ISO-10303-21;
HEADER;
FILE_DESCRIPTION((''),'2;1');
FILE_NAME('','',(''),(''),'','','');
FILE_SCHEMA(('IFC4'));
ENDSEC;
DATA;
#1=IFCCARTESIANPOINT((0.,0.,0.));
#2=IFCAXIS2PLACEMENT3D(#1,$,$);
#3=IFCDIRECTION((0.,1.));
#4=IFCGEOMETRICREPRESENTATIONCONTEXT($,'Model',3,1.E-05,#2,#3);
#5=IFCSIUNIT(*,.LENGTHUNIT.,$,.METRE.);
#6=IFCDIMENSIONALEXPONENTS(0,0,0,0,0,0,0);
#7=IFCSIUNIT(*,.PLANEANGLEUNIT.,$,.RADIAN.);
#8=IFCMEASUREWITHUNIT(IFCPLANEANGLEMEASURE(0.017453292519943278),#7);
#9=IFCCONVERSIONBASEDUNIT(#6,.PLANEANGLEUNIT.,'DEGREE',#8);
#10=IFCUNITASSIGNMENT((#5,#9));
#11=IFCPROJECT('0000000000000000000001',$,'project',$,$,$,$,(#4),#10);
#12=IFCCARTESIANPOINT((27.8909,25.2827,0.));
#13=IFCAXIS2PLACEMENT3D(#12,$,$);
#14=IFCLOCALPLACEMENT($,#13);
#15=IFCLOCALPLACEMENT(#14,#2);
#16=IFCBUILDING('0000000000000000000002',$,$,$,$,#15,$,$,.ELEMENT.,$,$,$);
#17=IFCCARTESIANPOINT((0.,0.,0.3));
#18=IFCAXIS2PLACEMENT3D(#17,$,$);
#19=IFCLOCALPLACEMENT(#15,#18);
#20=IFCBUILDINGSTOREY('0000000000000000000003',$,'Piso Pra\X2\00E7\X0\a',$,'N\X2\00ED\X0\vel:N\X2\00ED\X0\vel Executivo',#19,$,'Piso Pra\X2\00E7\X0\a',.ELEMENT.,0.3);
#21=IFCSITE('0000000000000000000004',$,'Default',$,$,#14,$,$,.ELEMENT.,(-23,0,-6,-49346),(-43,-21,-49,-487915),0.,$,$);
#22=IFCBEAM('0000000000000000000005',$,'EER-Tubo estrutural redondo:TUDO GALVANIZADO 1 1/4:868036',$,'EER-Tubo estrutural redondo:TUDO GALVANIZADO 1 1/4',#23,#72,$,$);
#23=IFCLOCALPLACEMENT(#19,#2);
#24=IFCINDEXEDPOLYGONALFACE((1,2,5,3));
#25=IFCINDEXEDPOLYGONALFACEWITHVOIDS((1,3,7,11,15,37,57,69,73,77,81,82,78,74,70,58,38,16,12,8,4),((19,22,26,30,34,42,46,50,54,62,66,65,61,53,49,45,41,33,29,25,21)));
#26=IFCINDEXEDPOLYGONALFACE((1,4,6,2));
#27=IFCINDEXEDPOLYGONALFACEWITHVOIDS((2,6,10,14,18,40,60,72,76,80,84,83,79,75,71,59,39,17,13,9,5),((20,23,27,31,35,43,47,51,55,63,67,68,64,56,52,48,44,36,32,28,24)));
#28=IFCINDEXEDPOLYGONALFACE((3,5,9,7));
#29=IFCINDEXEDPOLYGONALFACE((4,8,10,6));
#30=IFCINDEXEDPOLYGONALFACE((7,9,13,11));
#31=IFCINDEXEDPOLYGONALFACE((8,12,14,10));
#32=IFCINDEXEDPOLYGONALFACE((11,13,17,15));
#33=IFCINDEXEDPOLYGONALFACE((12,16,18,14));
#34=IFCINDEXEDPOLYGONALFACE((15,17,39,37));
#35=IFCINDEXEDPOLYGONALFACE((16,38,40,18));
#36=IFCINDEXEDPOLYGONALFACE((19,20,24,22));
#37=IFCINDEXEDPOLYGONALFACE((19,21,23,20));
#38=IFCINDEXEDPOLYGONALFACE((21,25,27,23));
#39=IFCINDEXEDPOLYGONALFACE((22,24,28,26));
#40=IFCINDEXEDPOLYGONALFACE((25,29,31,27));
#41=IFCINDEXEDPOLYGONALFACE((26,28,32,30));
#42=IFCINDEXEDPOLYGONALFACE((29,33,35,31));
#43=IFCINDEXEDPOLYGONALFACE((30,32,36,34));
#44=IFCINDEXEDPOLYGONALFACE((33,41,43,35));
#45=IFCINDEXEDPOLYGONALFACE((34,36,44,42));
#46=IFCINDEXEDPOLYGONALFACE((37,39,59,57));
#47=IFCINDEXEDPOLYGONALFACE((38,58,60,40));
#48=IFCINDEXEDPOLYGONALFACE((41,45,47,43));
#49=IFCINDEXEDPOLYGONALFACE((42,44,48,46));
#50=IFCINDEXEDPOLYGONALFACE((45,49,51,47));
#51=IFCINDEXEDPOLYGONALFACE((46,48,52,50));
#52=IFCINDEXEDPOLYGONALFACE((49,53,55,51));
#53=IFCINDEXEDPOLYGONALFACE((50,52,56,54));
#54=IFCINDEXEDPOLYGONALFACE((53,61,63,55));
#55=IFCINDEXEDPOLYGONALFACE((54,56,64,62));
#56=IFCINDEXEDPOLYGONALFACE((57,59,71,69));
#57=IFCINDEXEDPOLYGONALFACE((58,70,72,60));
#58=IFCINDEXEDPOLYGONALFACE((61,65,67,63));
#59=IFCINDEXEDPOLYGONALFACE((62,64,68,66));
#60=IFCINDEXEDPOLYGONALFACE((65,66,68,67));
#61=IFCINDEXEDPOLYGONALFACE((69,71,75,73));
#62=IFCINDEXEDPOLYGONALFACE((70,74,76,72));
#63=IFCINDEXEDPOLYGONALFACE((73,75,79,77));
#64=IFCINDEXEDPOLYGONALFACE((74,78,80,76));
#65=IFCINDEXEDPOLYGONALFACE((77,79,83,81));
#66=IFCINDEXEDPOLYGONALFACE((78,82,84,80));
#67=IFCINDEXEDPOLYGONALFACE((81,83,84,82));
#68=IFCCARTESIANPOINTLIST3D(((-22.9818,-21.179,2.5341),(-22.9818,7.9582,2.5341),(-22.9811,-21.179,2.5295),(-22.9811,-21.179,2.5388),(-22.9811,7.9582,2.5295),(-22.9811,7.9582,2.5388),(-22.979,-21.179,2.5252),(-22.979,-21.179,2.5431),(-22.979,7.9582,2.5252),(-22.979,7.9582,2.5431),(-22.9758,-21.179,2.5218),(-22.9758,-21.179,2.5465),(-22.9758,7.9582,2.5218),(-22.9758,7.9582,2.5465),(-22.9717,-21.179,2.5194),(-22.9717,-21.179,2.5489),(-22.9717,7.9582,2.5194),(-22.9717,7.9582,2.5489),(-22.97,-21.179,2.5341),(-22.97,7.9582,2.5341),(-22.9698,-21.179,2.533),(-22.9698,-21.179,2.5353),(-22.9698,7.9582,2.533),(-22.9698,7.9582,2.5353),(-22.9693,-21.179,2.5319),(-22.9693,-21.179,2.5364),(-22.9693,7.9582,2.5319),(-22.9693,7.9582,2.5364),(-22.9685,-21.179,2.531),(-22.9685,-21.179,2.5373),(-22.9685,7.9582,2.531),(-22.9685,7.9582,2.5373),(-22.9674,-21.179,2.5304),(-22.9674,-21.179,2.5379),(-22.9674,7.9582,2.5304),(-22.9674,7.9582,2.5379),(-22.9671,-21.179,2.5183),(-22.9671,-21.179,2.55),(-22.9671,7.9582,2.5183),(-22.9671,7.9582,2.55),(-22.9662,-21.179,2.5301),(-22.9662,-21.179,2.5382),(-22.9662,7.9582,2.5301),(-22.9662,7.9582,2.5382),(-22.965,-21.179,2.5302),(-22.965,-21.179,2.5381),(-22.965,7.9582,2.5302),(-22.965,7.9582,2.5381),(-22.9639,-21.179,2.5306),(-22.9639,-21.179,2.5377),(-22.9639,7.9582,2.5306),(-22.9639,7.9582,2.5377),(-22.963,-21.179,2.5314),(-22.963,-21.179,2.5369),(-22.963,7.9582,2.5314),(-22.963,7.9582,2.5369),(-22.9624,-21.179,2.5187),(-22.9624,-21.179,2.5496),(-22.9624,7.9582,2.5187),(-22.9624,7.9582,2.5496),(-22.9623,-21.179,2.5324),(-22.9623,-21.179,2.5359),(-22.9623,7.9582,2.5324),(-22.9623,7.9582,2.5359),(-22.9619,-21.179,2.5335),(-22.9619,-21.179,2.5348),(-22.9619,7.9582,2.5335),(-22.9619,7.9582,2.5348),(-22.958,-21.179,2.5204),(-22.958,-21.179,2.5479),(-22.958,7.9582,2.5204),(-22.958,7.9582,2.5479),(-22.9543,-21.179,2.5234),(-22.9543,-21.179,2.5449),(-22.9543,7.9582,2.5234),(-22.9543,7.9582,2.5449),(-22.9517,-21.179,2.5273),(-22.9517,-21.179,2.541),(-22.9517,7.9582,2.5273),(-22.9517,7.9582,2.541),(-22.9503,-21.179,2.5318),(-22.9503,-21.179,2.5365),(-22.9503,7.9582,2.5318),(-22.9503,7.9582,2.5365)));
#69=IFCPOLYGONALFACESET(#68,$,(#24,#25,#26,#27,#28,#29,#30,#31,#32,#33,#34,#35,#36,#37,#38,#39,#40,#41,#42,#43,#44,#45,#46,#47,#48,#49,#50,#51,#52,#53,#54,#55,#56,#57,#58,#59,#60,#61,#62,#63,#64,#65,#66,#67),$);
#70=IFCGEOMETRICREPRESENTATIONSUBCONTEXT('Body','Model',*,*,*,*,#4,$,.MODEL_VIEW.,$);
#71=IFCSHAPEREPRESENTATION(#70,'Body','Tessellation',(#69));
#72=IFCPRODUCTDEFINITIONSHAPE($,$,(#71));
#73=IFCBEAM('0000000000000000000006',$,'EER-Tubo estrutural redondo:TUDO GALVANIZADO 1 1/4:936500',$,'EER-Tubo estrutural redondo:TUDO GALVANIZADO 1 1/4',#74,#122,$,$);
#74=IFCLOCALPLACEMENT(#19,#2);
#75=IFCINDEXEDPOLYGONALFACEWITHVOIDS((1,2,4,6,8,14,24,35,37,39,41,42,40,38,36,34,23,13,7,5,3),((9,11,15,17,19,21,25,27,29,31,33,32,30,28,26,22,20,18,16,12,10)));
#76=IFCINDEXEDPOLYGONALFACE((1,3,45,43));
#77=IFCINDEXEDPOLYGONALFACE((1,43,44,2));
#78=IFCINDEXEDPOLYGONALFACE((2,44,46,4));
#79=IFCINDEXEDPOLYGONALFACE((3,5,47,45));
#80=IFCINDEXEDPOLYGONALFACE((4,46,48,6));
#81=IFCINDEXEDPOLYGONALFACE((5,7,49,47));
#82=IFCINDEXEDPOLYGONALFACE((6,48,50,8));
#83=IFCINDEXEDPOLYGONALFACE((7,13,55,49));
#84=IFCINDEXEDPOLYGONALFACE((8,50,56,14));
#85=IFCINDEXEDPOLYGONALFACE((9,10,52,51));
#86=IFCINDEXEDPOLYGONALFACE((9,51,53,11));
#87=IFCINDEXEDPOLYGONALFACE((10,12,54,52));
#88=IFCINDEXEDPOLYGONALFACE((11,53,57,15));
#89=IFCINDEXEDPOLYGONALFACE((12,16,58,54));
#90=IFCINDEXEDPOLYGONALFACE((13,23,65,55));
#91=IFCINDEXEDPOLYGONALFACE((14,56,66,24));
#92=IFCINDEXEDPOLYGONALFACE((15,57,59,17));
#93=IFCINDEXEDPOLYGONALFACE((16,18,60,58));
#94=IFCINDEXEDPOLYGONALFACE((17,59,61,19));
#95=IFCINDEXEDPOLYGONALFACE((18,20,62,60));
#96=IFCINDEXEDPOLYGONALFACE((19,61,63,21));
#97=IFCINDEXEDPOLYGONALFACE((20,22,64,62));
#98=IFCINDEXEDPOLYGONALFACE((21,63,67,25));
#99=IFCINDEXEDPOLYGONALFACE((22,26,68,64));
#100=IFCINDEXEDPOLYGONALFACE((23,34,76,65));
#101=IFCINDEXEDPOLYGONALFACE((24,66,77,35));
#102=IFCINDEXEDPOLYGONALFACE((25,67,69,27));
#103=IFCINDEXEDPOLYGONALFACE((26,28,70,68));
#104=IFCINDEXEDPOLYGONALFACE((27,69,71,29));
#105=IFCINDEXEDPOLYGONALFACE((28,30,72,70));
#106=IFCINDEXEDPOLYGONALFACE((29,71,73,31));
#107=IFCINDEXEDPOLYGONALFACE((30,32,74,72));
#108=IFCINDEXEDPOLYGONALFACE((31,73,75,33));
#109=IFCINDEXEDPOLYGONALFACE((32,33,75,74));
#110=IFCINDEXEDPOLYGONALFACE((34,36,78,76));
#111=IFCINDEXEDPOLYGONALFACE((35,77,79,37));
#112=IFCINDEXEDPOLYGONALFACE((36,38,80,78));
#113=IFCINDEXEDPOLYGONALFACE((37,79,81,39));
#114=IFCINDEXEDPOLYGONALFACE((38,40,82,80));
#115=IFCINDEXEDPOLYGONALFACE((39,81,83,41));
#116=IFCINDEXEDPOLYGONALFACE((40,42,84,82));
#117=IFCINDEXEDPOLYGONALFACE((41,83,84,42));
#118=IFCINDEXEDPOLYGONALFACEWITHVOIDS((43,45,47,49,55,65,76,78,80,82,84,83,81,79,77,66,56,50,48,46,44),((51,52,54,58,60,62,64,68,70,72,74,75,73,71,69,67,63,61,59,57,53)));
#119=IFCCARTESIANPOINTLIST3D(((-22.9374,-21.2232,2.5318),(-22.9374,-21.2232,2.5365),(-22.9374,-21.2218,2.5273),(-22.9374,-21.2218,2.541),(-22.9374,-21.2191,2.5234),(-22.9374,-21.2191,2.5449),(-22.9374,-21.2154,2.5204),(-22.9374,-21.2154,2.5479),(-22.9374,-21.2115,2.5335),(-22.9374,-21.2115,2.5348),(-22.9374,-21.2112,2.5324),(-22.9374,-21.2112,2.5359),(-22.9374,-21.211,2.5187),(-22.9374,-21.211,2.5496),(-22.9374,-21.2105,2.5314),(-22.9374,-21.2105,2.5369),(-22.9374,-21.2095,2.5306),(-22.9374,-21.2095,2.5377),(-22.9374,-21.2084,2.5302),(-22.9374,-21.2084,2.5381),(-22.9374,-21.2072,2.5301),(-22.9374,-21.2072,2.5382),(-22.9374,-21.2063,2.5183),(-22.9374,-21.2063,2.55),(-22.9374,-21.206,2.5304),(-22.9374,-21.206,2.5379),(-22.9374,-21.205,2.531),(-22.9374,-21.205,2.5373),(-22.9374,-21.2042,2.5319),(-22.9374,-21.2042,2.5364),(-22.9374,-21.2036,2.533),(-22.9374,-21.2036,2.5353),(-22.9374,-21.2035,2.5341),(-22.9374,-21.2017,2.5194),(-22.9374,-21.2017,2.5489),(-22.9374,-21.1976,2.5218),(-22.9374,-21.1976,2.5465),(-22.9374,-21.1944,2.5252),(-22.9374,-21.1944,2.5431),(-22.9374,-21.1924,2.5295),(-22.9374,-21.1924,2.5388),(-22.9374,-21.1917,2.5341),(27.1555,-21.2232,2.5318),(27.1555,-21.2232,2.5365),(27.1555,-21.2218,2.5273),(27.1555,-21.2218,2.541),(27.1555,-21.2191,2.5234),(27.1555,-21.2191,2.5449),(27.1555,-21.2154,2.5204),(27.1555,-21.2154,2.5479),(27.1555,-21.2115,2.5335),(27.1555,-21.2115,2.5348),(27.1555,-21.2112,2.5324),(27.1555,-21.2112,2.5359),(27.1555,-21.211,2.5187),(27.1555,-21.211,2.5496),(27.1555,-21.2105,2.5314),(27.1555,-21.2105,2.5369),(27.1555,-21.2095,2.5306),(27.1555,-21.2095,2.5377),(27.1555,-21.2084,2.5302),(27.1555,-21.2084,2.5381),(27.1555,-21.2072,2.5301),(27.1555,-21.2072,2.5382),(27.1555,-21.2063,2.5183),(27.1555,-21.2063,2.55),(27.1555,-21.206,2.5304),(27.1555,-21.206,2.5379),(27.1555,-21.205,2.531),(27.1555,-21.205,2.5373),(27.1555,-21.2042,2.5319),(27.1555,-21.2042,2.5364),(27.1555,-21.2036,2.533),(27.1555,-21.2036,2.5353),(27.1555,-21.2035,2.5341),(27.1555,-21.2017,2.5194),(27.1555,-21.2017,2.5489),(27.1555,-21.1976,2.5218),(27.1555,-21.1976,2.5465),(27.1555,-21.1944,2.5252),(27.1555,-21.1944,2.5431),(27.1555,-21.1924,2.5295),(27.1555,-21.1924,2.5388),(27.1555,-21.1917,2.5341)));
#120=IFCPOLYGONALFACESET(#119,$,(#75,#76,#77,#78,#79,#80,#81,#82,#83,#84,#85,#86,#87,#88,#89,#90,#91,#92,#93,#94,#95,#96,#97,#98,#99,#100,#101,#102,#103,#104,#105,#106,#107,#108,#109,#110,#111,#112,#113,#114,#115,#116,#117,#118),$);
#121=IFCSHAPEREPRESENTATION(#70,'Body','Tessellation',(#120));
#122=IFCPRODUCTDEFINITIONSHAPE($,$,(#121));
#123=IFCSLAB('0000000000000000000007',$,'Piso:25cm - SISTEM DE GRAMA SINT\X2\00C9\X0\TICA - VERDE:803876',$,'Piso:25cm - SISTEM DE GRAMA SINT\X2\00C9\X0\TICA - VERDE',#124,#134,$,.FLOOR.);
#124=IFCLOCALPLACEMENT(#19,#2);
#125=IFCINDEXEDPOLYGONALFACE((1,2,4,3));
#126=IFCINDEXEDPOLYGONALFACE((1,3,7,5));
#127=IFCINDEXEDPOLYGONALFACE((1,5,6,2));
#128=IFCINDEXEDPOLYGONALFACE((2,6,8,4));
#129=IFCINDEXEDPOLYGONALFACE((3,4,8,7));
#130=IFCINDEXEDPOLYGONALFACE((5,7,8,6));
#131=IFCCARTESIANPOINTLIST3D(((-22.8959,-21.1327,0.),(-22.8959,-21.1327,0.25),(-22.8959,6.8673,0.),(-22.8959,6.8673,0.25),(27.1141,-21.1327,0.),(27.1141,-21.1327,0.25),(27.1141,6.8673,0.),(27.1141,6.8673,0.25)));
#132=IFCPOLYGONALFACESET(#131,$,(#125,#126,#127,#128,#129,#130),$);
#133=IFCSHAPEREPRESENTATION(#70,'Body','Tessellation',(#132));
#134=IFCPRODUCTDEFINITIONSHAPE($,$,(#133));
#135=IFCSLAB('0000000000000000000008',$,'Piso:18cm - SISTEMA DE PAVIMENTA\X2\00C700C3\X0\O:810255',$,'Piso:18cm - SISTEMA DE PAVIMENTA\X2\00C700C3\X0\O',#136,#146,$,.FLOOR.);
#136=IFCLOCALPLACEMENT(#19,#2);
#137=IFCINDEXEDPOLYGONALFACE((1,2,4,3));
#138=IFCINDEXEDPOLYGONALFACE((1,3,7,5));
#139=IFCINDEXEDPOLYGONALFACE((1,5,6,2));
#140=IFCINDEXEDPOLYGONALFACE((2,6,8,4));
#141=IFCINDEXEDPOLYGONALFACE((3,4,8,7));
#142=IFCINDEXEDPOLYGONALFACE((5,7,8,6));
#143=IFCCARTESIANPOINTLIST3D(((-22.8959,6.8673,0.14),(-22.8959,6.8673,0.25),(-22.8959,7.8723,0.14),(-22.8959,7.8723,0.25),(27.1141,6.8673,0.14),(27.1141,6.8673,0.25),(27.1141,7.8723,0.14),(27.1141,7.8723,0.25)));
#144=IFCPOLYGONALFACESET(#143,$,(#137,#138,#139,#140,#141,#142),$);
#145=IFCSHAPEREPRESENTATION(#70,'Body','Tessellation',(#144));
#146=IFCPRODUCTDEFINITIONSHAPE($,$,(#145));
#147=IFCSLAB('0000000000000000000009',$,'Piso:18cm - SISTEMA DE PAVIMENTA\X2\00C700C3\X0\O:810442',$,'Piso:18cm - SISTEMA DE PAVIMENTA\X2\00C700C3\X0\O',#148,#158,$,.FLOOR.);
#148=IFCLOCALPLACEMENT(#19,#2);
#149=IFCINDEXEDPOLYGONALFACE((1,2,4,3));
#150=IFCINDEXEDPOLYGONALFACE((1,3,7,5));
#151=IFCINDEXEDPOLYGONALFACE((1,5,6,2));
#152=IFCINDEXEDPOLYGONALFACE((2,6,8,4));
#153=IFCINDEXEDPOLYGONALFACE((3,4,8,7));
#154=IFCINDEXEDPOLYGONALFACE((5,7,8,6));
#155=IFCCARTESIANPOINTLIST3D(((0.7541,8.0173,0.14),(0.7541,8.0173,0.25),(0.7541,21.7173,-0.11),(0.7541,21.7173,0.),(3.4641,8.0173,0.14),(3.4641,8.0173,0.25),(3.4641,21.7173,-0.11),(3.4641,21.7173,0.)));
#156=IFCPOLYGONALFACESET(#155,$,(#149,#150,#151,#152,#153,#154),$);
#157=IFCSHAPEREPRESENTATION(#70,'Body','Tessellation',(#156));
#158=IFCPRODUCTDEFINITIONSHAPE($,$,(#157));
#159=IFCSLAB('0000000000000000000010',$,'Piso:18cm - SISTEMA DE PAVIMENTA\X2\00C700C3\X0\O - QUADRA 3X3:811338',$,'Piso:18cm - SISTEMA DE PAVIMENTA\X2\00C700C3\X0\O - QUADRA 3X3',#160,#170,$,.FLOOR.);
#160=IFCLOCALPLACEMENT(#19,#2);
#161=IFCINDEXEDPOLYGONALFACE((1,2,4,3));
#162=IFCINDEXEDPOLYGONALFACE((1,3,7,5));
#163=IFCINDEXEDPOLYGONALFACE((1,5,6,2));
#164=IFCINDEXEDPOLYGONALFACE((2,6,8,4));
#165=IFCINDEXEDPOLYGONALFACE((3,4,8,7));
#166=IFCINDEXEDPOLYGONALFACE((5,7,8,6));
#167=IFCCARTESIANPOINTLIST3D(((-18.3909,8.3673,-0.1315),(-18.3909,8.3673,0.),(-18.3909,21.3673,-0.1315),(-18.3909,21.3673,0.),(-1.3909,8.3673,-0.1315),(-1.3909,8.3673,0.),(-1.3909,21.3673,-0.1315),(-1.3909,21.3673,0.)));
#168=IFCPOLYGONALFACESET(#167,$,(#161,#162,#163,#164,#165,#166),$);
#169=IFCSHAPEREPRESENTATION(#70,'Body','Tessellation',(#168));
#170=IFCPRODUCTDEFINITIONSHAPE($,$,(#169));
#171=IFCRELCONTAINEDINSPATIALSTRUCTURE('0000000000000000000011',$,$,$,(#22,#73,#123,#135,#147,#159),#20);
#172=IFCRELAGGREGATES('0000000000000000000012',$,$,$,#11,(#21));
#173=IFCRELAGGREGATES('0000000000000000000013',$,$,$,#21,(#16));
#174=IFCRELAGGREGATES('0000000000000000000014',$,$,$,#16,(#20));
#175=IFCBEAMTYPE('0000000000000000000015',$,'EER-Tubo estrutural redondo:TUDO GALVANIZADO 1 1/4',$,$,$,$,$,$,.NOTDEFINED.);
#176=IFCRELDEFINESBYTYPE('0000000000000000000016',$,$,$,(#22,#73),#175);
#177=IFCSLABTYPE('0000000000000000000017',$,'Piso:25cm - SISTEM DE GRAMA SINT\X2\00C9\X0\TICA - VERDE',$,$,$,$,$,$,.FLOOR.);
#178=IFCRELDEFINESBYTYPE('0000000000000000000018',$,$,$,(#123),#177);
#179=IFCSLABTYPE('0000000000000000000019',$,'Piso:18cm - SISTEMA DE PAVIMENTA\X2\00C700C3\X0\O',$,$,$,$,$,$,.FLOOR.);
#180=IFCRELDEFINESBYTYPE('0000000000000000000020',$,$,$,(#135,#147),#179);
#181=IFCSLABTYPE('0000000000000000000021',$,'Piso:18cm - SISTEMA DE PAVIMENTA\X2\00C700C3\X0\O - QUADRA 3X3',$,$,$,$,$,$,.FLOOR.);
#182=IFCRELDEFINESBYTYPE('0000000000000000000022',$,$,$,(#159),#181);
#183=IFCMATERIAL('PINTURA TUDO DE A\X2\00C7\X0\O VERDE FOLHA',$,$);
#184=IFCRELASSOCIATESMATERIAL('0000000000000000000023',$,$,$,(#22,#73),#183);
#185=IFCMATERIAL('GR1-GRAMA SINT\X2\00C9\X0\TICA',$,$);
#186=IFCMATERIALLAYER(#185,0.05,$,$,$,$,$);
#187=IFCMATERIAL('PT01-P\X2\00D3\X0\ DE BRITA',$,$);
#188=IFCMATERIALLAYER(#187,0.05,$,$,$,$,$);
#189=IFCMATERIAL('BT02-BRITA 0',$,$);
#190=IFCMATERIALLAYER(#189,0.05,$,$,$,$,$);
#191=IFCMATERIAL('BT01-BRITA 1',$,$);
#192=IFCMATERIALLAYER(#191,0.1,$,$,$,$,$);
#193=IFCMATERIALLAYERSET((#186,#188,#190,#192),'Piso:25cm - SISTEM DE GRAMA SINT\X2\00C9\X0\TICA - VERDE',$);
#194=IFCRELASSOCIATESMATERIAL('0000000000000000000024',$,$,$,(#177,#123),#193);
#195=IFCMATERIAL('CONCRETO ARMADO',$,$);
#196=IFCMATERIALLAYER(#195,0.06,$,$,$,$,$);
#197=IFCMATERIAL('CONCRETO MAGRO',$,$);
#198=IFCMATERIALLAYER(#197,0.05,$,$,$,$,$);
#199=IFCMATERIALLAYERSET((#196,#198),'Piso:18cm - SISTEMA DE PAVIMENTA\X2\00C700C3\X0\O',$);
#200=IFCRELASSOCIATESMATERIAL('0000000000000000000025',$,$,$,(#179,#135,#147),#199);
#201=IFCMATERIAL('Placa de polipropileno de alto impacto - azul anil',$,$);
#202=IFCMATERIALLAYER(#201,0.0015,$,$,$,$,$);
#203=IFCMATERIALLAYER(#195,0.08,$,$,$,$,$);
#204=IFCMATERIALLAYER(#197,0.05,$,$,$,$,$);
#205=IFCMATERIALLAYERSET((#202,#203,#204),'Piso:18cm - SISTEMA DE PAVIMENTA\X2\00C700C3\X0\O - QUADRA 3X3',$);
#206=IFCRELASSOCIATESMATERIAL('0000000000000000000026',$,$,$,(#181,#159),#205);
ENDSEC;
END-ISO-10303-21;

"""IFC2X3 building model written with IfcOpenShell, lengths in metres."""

from ifc_helpers import new_model, entity, si_unit, converted_unit, direction, frame, frame_2d, origin, origin_2d_with_axis, place, context, subcontext, project, spatial, rectangle, hollow_circle, extrude, clip, halfspace, material, layer, layer_set, layer_usage, type_object, element, save


model = new_model("IFC2X3")

# Units and contexts
model_context = context("Model", 3, precision=1e-05, world=origin(), true_north=direction((0.0, 1.0)))
body_context = subcontext(model_context, "Body", "Model", "MODEL_VIEW")
ifc_project = project(units=[si_unit("LENGTHUNIT", "METRE"), converted_unit("PLANEANGLEUNIT", "DEGREE", entity("IfcPlaneAngleMeasure", 0.017453292519943278), si_unit("PLANEANGLEUNIT", "RADIAN"), dimensions=[0, 0, 0, 0, 0, 0, 0])], contexts=[model_context])

# Site, building, storey
site_placement = place(None, frame((27.8909, 25.2827, 0.0)))
site = spatial("IfcSite", under=ifc_project, at=site_placement, Name="Default", CompositionType="ELEMENT", RefLatitude=(-23, 0, -6, -49346), RefLongitude=(-43, -21, -49, -487915), RefElevation=0.0)
building_placement = place(site_placement, origin())
building = spatial("IfcBuilding", under=site, at=building_placement, CompositionType="ELEMENT")
storey_placement = place(building_placement, frame((0.0, 0.0, 0.3)))
storey = spatial("IfcBuildingStorey", under=building, at=storey_placement, Name="Piso Praça", ObjectType="Nível:Nível Executivo", LongName="Piso Praça", CompositionType="ELEMENT", Elevation=0.3)

# Shared definitions
ifc_material_1 = material(Name="PINTURA TUDO DE AÇO VERDE FOLHA")

# Beams
beam_type_1 = type_object("IfcBeamType", Name="EER-Tubo estrutural redondo:TUDO GALVANIZADO 1 1/4", PredefinedType="NOTDEFINED")
beam_1_placement = place(storey_placement, frame((-22.9659, -21.2073, 2.55), z_axis=(0.0, 0.0, 1.0), x_axis=(0.0, 1.0, 0.0)))
element("IfcBeam", 1, at=beam_1_placement, inside=storey, type_object=beam_type_1, material=ifc_material_1, Name="EER-Tubo estrutural redondo:TUDO GALVANIZADO 1 1/4:868036", ObjectType="EER-Tubo estrutural redondo:TUDO GALVANIZADO 1 1/4", context=body_context, shape_type="SweptSolid", body=[
    extrude(hollow_circle(Radius=0.0159, WallThickness=0.0118, at=origin_2d_with_axis()), frame((0.0284, 0.0, -0.0159), z_axis=(1.0, 0.0, 0.0), x_axis=(0.0, 1.0, 0.0)), (0.0, 0.0, 1.0), 29.1371),
])
beam_2_placement = place(storey_placement, frame((-22.9659, -21.2075, 2.55)))
element("IfcBeam", 2, at=beam_2_placement, inside=storey, type_object=beam_type_1, material=ifc_material_1, Name="EER-Tubo estrutural redondo:TUDO GALVANIZADO 1 1/4:936500", ObjectType="EER-Tubo estrutural redondo:TUDO GALVANIZADO 1 1/4", context=body_context, shape_type="SweptSolid", body=[
    extrude(hollow_circle(Radius=0.0159, WallThickness=0.0118, at=origin_2d_with_axis()), frame((0.0286, 0.0, -0.0159), z_axis=(1.0, 0.0, 0.0), x_axis=(0.0, 1.0, 0.0)), (0.0, 0.0, 1.0), 50.0929),
])

# Slabs
ifc_material_2 = material(Name="GR1-GRAMA SINTÉTICA")
ifc_layer_1 = layer(ifc_material_2, 0.05)
ifc_material_3 = material(Name="PT01-PÓ DE BRITA")
ifc_layer_2 = layer(ifc_material_3, 0.05)
ifc_material_4 = material(Name="BT02-BRITA 0")
ifc_layer_3 = layer(ifc_material_4, 0.05)
ifc_material_5 = material(Name="BT01-BRITA 1")
ifc_layer_4 = layer(ifc_material_5, 0.1)
ifc_layer_set_1 = layer_set([ifc_layer_1, ifc_layer_2, ifc_layer_3, ifc_layer_4], Name="Piso:25cm - SISTEM DE GRAMA SINTÉTICA - VERDE")
ifc_layer_usage_1 = layer_usage(ifc_layer_set_1, "AXIS3", "POSITIVE", 0.0)
slab_type_1 = type_object("IfcSlabType", Name="Piso:25cm - SISTEM DE GRAMA SINTÉTICA - VERDE", PredefinedType="FLOOR", material=ifc_layer_set_1)
slab_1_placement = place(storey_placement, origin())
element("IfcSlab", 3, at=slab_1_placement, inside=storey, type_object=slab_type_1, material=ifc_layer_usage_1, Name="Piso:25cm - SISTEM DE GRAMA SINTÉTICA - VERDE:803876", ObjectType="Piso:25cm - SISTEM DE GRAMA SINTÉTICA - VERDE", PredefinedType="FLOOR", context=body_context, shape_type="SweptSolid", body=[
    extrude(rectangle(XDim=28.0, YDim=50.01, at=origin_2d_with_axis()), frame((2.1091, -7.1327, 0.25), z_axis=(0.0, 0.0, -1.0), x_axis=(0.0, 1.0, 0.0)), (0.0, 0.0, 1.0), 0.25),
])
ifc_material_6 = material(Name="CONCRETO ARMADO")
ifc_layer_5 = layer(ifc_material_6, 0.06)
ifc_material_7 = material(Name="CONCRETO MAGRO")
ifc_layer_6 = layer(ifc_material_7, 0.05)
ifc_layer_set_2 = layer_set([ifc_layer_5, ifc_layer_6], Name="Piso:18cm - SISTEMA DE PAVIMENTAÇÃO")
ifc_layer_usage_2 = layer_usage(ifc_layer_set_2, "AXIS3", "POSITIVE", 0.0)
slab_type_2 = type_object("IfcSlabType", Name="Piso:18cm - SISTEMA DE PAVIMENTAÇÃO", PredefinedType="FLOOR", material=ifc_layer_set_2)
slab_2_placement = place(storey_placement, origin())
element("IfcSlab", 4, at=slab_2_placement, inside=storey, type_object=slab_type_2, material=ifc_layer_usage_2, Name="Piso:18cm - SISTEMA DE PAVIMENTAÇÃO:810255", ObjectType="Piso:18cm - SISTEMA DE PAVIMENTAÇÃO", PredefinedType="FLOOR", context=body_context, shape_type="SweptSolid", body=[
    extrude(rectangle(XDim=1.005, YDim=50.01, at=frame_2d((0.0, 0.0), x_axis=(1.0, 0.0))), frame((2.1091, 7.3698, 0.25), z_axis=(0.0, 0.0, -1.0), x_axis=(0.0, 1.0, 0.0)), (0.0, 0.0, 1.0), 0.11),
])
slab_3_placement = place(storey_placement, origin())
element("IfcSlab", 5, at=slab_3_placement, inside=storey, type_object=slab_type_2, material=ifc_layer_usage_2, Name="Piso:18cm - SISTEMA DE PAVIMENTAÇÃO:810442", ObjectType="Piso:18cm - SISTEMA DE PAVIMENTAÇÃO", PredefinedType="FLOOR", context=body_context, shape_type="SweptSolid", body=[
    clip(clip(extrude(rectangle(XDim=13.7023, YDim=2.71, at=frame_2d((0.0, 0.0), x_axis=(1.0, 0.0))), frame((2.1091, 14.8673, 0.125), z_axis=(0.0, -0.018245, -0.999834), x_axis=(0.0, 0.999834, -0.018245)), (0.018245, 0.0, 0.999834), 0.11), halfspace(frame((2.1091, 14.8673, 0.015), z_axis=(0.0, -0.018245, -0.999834), x_axis=(0.0, -0.999834, 0.018245)), False)), halfspace(frame((2.1091, 14.8673, 0.125), z_axis=(0.0, 0.018245, 0.999834), x_axis=(0.0, -0.999834, 0.018245)), False)),
])
ifc_material_8 = material(Name="Placa de polipropileno de alto impacto - azul anil")
ifc_layer_7 = layer(ifc_material_8, 0.0015)
ifc_layer_8 = layer(ifc_material_6, 0.08)
ifc_layer_9 = layer(ifc_material_7, 0.05)
ifc_layer_set_3 = layer_set([ifc_layer_7, ifc_layer_8, ifc_layer_9], Name="Piso:18cm - SISTEMA DE PAVIMENTAÇÃO - QUADRA 3X3")
ifc_layer_usage_3 = layer_usage(ifc_layer_set_3, "AXIS3", "POSITIVE", 0.0)
slab_type_3 = type_object("IfcSlabType", Name="Piso:18cm - SISTEMA DE PAVIMENTAÇÃO - QUADRA 3X3", PredefinedType="FLOOR", material=ifc_layer_set_3)
slab_4_placement = place(storey_placement, origin())
element("IfcSlab", 6, at=slab_4_placement, inside=storey, type_object=slab_type_3, material=ifc_layer_usage_3, Name="Piso:18cm - SISTEMA DE PAVIMENTAÇÃO - QUADRA 3X3:811338", ObjectType="Piso:18cm - SISTEMA DE PAVIMENTAÇÃO - QUADRA 3X3", PredefinedType="FLOOR", context=body_context, shape_type="SweptSolid", body=[
    extrude(rectangle(XDim=13.0, YDim=17.0, at=frame_2d((0.0, 0.0), x_axis=(1.0, 0.0))), frame((-9.8909, 14.8673, 0.0), z_axis=(0.0, 0.0, -1.0), x_axis=(0.0, 1.0, 0.0)), (0.0, 0.0, 1.0), 0.1315),
])

save(model, "model.ifc")
